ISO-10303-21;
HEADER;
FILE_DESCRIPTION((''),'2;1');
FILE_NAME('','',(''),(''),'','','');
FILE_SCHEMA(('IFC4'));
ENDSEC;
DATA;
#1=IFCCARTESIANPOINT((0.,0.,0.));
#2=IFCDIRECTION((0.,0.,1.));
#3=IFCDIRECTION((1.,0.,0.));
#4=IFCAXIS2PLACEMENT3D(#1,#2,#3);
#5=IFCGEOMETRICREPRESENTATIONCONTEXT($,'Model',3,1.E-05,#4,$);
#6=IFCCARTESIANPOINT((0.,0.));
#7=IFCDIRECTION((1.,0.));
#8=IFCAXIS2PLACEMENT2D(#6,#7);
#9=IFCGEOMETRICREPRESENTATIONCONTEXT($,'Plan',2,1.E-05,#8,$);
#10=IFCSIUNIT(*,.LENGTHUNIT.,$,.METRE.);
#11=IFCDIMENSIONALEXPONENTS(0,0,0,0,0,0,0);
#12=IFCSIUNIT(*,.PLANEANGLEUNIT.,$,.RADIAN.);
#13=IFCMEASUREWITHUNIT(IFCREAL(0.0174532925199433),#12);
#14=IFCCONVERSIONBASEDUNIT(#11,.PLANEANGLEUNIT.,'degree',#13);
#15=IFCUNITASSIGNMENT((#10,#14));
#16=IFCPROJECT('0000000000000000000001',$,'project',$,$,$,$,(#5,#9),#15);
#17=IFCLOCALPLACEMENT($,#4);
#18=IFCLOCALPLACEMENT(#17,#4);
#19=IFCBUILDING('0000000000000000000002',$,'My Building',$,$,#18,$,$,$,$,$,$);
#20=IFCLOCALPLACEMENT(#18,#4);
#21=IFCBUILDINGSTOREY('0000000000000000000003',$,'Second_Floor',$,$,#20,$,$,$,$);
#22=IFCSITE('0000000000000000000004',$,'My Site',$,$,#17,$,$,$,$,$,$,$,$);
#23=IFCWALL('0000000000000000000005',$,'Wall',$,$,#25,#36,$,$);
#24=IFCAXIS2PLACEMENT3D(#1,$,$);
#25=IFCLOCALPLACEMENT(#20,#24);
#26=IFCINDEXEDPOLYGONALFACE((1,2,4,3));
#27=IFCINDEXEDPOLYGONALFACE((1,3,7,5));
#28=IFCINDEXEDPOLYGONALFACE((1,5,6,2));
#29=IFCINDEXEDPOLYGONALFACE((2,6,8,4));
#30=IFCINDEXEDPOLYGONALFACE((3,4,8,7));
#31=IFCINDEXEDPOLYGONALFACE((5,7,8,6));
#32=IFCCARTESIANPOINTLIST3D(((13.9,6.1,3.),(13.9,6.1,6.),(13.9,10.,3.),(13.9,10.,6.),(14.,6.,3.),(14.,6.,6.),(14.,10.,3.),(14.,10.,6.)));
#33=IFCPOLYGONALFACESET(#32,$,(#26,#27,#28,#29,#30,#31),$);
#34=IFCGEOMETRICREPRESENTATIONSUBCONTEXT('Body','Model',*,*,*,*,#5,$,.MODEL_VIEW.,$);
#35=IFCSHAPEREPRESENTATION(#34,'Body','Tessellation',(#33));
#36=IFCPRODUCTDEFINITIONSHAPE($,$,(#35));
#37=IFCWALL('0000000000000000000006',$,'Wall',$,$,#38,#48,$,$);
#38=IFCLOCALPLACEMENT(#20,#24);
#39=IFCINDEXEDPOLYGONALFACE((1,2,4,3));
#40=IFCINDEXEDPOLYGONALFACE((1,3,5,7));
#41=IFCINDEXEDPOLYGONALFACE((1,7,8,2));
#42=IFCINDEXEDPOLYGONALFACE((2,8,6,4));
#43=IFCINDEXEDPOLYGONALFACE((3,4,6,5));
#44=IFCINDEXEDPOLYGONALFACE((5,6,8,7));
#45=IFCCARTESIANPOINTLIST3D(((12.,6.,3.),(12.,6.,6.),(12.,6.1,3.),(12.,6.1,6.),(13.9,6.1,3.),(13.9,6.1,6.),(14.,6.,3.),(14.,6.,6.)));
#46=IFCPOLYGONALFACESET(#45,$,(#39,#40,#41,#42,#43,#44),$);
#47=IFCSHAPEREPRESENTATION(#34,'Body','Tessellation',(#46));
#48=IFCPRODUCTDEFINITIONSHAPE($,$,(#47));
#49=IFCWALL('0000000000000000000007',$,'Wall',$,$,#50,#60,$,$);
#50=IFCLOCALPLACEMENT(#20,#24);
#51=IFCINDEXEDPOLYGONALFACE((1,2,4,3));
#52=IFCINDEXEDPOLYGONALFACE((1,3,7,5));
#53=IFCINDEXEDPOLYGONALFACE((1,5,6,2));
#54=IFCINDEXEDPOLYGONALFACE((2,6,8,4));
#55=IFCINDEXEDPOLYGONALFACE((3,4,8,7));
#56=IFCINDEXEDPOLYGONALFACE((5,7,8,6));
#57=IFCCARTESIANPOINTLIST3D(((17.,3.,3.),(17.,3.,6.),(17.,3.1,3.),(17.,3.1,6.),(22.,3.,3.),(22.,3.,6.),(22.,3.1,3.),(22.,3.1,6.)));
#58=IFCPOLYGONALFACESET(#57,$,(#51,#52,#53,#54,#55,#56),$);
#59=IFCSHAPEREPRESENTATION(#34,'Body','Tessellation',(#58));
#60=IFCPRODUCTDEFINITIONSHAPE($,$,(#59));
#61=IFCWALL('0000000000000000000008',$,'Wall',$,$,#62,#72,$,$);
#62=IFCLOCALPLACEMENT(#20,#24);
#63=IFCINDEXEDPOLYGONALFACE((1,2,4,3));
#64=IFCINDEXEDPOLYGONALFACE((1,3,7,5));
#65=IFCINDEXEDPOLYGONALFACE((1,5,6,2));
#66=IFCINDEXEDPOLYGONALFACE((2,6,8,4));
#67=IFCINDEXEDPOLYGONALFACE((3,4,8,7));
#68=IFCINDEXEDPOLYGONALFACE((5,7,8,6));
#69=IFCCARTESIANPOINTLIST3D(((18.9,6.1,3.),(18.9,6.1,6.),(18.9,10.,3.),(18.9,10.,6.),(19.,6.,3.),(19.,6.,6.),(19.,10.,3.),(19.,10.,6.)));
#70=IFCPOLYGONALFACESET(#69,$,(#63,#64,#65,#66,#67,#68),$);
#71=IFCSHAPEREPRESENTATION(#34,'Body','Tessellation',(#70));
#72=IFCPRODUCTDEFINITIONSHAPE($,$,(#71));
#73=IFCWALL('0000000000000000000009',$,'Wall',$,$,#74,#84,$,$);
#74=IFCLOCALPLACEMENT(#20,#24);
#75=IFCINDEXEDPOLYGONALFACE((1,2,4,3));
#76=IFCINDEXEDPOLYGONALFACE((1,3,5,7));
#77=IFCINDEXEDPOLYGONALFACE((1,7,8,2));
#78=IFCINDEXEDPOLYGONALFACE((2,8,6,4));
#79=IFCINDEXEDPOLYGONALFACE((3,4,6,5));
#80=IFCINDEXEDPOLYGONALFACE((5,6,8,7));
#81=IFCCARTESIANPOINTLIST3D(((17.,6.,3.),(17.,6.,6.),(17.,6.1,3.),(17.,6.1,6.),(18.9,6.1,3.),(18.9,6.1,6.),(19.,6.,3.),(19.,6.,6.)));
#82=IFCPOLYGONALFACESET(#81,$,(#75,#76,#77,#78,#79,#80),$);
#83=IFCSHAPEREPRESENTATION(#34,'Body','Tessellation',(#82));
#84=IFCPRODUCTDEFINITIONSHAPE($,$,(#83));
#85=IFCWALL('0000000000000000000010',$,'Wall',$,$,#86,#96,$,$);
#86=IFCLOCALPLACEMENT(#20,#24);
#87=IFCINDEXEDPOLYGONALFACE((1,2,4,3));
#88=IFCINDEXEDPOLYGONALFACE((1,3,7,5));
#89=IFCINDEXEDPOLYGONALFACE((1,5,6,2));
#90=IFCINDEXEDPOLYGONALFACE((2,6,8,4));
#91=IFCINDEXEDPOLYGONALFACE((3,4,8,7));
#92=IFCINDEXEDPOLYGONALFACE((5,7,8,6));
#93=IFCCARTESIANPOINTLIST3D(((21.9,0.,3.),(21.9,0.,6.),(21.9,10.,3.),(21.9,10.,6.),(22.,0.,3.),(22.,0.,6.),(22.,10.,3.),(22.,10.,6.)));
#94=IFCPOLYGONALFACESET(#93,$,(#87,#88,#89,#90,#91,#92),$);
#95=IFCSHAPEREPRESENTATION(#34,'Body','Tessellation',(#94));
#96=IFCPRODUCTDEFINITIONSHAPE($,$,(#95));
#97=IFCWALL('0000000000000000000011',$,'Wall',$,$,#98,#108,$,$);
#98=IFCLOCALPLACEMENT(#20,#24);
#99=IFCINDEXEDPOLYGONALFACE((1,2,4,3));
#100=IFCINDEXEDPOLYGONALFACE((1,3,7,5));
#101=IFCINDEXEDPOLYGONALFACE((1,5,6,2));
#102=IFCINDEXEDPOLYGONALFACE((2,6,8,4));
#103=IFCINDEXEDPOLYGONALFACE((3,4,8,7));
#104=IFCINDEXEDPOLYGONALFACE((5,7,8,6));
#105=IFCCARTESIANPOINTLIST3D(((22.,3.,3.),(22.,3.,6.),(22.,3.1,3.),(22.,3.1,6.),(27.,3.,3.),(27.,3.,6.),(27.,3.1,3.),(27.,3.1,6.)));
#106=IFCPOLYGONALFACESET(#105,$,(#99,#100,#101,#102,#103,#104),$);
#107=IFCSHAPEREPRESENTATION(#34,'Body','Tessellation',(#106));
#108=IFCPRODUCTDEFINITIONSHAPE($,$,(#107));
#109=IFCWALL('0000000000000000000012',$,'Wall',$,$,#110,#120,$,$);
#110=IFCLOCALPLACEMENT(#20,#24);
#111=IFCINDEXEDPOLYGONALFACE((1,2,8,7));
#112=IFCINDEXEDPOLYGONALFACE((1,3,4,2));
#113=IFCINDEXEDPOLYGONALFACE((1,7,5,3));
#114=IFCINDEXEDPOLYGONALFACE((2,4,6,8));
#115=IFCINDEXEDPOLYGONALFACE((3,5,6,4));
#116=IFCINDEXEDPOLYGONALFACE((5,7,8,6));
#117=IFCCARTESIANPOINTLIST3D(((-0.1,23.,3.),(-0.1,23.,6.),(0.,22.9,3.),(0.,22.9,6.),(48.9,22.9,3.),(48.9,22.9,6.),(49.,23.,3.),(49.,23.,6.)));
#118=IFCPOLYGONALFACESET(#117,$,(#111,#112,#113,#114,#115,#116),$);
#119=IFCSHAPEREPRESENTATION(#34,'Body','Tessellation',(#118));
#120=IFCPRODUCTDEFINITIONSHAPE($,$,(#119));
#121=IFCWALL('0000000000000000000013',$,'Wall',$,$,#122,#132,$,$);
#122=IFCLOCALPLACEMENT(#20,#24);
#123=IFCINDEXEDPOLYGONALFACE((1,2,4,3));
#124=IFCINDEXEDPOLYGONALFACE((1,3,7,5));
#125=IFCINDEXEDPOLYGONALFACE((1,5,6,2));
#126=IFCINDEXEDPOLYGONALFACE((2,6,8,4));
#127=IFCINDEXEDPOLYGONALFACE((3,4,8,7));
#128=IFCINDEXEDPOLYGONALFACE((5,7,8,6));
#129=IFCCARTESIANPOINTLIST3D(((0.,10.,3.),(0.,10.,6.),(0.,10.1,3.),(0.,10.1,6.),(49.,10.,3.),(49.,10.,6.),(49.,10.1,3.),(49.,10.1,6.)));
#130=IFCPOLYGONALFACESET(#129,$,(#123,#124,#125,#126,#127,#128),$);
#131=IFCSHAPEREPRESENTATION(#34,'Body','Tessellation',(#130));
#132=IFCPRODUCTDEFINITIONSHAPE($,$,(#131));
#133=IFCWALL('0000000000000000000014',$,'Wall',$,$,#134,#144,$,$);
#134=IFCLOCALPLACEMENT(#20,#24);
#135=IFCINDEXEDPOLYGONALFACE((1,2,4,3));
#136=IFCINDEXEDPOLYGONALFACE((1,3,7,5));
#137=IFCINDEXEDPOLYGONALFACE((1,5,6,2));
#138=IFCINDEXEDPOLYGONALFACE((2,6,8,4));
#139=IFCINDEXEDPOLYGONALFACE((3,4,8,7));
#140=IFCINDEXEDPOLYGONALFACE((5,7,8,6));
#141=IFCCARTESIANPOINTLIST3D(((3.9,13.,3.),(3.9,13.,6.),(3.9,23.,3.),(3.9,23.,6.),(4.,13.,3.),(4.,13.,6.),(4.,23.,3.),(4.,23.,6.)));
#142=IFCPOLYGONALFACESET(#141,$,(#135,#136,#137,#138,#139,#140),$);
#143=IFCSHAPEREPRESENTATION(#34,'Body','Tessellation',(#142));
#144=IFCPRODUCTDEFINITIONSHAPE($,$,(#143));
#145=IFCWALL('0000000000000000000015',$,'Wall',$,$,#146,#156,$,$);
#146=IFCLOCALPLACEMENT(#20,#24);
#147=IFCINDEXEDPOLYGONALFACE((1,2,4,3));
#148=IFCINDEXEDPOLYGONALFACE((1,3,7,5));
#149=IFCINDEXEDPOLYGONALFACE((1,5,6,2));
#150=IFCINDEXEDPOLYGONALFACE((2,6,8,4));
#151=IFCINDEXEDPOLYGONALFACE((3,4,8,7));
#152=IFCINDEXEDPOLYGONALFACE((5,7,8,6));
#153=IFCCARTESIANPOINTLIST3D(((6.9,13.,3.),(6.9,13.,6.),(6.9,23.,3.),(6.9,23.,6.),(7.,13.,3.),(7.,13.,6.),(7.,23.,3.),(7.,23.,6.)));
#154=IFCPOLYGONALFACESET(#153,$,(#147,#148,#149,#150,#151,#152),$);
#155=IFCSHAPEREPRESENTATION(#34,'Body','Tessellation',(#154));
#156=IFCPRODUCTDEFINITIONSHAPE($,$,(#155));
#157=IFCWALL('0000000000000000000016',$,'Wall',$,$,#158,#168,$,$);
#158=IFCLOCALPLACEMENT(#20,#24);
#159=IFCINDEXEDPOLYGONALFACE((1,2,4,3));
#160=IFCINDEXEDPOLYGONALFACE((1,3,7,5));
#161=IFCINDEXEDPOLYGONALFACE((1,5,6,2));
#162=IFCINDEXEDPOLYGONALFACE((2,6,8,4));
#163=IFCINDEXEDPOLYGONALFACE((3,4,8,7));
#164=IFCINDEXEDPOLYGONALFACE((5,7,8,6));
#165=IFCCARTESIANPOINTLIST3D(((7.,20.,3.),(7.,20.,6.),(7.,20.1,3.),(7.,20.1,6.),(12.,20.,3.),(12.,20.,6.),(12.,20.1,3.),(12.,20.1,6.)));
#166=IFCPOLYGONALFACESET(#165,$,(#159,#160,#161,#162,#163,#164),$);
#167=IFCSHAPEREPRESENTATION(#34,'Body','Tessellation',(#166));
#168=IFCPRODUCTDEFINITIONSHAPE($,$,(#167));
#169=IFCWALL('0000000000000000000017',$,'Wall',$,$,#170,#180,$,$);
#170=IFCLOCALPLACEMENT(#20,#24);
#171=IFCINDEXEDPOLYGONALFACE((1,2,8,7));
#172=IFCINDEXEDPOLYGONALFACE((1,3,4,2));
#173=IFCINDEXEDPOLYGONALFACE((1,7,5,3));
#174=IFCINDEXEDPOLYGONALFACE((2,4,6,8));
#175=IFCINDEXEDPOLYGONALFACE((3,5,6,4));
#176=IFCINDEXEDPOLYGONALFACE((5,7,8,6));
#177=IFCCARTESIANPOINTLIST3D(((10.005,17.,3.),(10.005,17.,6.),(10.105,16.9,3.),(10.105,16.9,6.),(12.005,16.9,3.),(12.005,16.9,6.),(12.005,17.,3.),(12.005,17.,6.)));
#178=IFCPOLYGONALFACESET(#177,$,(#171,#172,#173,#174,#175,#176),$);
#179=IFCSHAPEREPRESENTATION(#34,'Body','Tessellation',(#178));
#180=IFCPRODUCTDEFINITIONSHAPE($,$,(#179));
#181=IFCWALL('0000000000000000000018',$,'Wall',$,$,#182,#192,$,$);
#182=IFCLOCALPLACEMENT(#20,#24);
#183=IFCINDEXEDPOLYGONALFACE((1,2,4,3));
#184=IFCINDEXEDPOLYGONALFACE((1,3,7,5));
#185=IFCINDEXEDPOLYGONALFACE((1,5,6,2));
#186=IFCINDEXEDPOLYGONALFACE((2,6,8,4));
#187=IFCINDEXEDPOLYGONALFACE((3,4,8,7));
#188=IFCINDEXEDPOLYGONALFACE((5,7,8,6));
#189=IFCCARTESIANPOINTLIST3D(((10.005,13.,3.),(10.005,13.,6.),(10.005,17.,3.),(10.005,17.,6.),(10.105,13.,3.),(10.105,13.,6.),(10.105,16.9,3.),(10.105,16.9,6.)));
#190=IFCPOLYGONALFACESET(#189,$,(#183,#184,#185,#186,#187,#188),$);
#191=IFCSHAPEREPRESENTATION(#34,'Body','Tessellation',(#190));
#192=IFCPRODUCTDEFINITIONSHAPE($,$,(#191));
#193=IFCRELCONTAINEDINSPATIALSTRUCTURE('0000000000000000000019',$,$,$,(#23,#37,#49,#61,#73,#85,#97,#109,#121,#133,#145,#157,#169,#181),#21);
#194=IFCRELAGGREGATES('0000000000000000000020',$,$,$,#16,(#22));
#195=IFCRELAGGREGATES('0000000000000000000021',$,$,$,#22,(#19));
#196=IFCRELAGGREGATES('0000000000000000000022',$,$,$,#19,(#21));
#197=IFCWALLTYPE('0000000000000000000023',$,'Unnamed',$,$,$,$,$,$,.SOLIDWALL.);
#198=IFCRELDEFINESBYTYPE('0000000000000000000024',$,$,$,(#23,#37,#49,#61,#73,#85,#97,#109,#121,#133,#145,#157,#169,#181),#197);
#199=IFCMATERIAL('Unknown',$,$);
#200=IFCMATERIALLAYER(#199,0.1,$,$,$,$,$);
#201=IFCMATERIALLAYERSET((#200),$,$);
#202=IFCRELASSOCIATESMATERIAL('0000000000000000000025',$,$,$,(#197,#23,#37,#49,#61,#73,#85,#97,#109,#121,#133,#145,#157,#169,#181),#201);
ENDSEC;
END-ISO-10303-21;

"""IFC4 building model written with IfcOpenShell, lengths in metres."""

from ifc_helpers import new_model, entity, si_unit, converted_unit, frame, origin_with_axes, origin_2d_with_axis, place, context, subcontext, project, spatial, line, indexed_curve, outline, extrude, material, layer, layer_set, layer_usage, type_object, element, save


model = new_model("IFC4")

# Units and contexts
model_context = context("Model", 3, precision=1e-05, world=origin_with_axes())
plan_context = context("Plan", 2, precision=1e-05, world=origin_2d_with_axis())
body_context = subcontext(model_context, "Body", "Model", "MODEL_VIEW")
ifc_project = project(units=[si_unit("LENGTHUNIT", "METRE"), converted_unit("PLANEANGLEUNIT", "degree", entity("IfcReal", 0.0174532925199433), si_unit("PLANEANGLEUNIT", "RADIAN"), dimensions=[0, 0, 0, 0, 0, 0, 0])], contexts=[model_context, plan_context])

# Site, building, storey
site_placement = place(None, origin_with_axes())
site = spatial("IfcSite", under=ifc_project, at=site_placement, Name="My Site")
building_placement = place(site_placement, origin_with_axes())
building = spatial("IfcBuilding", under=site, at=building_placement, Name="My Building")
storey_placement = place(building_placement, origin_with_axes())
storey = spatial("IfcBuildingStorey", under=building, at=storey_placement, Name="Second_Floor")

# Shared definitions
ifc_material = material(Name="Unknown")

# Walls
ifc_layer_1 = layer(ifc_material, 0.1)
ifc_layer_set_1 = layer_set([ifc_layer_1])
wall_type = type_object("IfcWallType", Name="Unnamed", PredefinedType="SOLIDWALL", material=ifc_layer_set_1)
ifc_layer_usage_1 = layer_usage(ifc_layer_set_1, "AXIS2", "POSITIVE", 0.0)
wall_1_placement = place(storey_placement, frame((14.0, 6.0, 3.0), z_axis=(0.0, 0.0, 1.0), x_axis=(0.0, 1.0, 0.0)))
element("IfcWall", 1, at=wall_1_placement, inside=storey, type_object=wall_type, material=ifc_layer_usage_1, Name="Wall", context=body_context, shape_type="SweptSolid", body=[
    extrude(outline(indexed_curve([(0.0, 0.0), (0.1, 0.1), (4.0, 0.1), (4.0, 0.0)], segments=[line(1, 2, 3, 4, 1)])), origin_with_axes(), (0.0, 0.0, 1.0), 3.0),
])
ifc_layer_usage_2 = layer_usage(ifc_layer_set_1, "AXIS2", "POSITIVE", 0.0)
wall_2_placement = place(storey_placement, frame((12.0, 6.0, 3.0), z_axis=(0.0, 0.0, 1.0), x_axis=(1.0, 0.0, 0.0)))
element("IfcWall", 2, at=wall_2_placement, inside=storey, type_object=wall_type, material=ifc_layer_usage_2, Name="Wall", context=body_context, shape_type="SweptSolid", body=[
    extrude(outline(indexed_curve([(0.0, 0.0), (0.0, 0.1), (1.9, 0.1), (2.0, 0.0)], segments=[line(1, 2, 3, 4, 1)])), origin_with_axes(), (0.0, 0.0, 1.0), 3.0),
])
ifc_layer_usage_3 = layer_usage(ifc_layer_set_1, "AXIS2", "POSITIVE", 0.0)
wall_3_placement = place(storey_placement, frame((17.0, 3.0, 3.0), z_axis=(0.0, 0.0, 1.0), x_axis=(1.0, 0.0, 0.0)))
element("IfcWall", 3, at=wall_3_placement, inside=storey, type_object=wall_type, material=ifc_layer_usage_3, Name="Wall", context=body_context, shape_type="SweptSolid", body=[
    extrude(outline(indexed_curve([(0.0, 0.0), (0.0, 0.1), (5.0, 0.1), (5.0, 0.0)], segments=[line(1, 2, 3, 4, 1)])), origin_with_axes(), (0.0, 0.0, 1.0), 3.0),
])
ifc_layer_usage_4 = layer_usage(ifc_layer_set_1, "AXIS2", "POSITIVE", 0.0)
wall_4_placement = place(storey_placement, frame((19.0, 6.0, 3.0), z_axis=(0.0, 0.0, 1.0), x_axis=(0.0, 1.0, 0.0)))
element("IfcWall", 4, at=wall_4_placement, inside=storey, type_object=wall_type, material=ifc_layer_usage_4, Name="Wall", context=body_context, shape_type="SweptSolid", body=[
    extrude(outline(indexed_curve([(0.0, 0.0), (0.1, 0.1), (4.0, 0.1), (4.0, 0.0)], segments=[line(1, 2, 3, 4, 1)])), origin_with_axes(), (0.0, 0.0, 1.0), 3.0),
])
ifc_layer_usage_5 = layer_usage(ifc_layer_set_1, "AXIS2", "POSITIVE", 0.0)
wall_5_placement = place(storey_placement, frame((17.0, 6.0, 3.0), z_axis=(0.0, 0.0, 1.0), x_axis=(1.0, 0.0, 0.0)))
element("IfcWall", 5, at=wall_5_placement, inside=storey, type_object=wall_type, material=ifc_layer_usage_5, Name="Wall", context=body_context, shape_type="SweptSolid", body=[
    extrude(outline(indexed_curve([(0.0, 0.0), (0.0, 0.1), (1.9, 0.1), (2.0, 0.0)], segments=[line(1, 2, 3, 4, 1)])), origin_with_axes(), (0.0, 0.0, 1.0), 3.0),
])
ifc_layer_usage_6 = layer_usage(ifc_layer_set_1, "AXIS2", "POSITIVE", 0.0)
wall_6_placement = place(storey_placement, frame((21.9, 10.0, 3.0), z_axis=(0.0, 0.0, 1.0), x_axis=(0.0, -1.0, 0.0)))
element("IfcWall", 6, at=wall_6_placement, inside=storey, type_object=wall_type, material=ifc_layer_usage_6, Name="Wall", context=body_context, shape_type="SweptSolid", body=[
    extrude(outline(indexed_curve([(0.0, 0.0), (0.0, 0.1), (10.0, 0.1), (10.0, 0.0)], segments=[line(1, 2, 3, 4, 1)])), origin_with_axes(), (0.0, 0.0, 1.0), 3.0),
])
ifc_layer_usage_7 = layer_usage(ifc_layer_set_1, "AXIS2", "POSITIVE", 0.0)
wall_7_placement = place(storey_placement, frame((22.0, 3.0, 3.0), z_axis=(0.0, 0.0, 1.0), x_axis=(1.0, 0.0, 0.0)))
element("IfcWall", 7, at=wall_7_placement, inside=storey, type_object=wall_type, material=ifc_layer_usage_7, Name="Wall", context=body_context, shape_type="SweptSolid", body=[
    extrude(outline(indexed_curve([(0.0, 0.0), (0.0, 0.1), (5.0, 0.1), (5.0, 0.0)], segments=[line(1, 2, 3, 4, 1)])), origin_with_axes(), (0.0, 0.0, 1.0), 3.0),
])
ifc_layer_usage_8 = layer_usage(ifc_layer_set_1, "AXIS2", "POSITIVE", 0.0)
wall_8_placement = place(storey_placement, frame((0.0, 22.9, 3.0), z_axis=(0.0, 0.0, 1.0), x_axis=(1.0, 0.0, 0.0)))
element("IfcWall", 8, at=wall_8_placement, inside=storey, type_object=wall_type, material=ifc_layer_usage_8, Name="Wall", context=body_context, shape_type="SweptSolid", body=[
    extrude(outline(indexed_curve([(0.0, 0.0), (-0.1, 0.1), (49.0, 0.1), (48.9, 0.0)], segments=[line(1, 2, 3, 4, 1)])), origin_with_axes(), (0.0, 0.0, 1.0), 3.0),
])
ifc_layer_usage_9 = layer_usage(ifc_layer_set_1, "AXIS2", "POSITIVE", 0.0)
wall_9_placement = place(storey_placement, frame((0.0, 10.0, 3.0), z_axis=(0.0, 0.0, 1.0), x_axis=(1.0, 0.0, 0.0)))
element("IfcWall", 9, at=wall_9_placement, inside=storey, type_object=wall_type, material=ifc_layer_usage_9, Name="Wall", context=body_context, shape_type="SweptSolid", body=[
    extrude(outline(indexed_curve([(0.0, 0.0), (0.0, 0.1), (49.0, 0.1), (49.0, 0.0)], segments=[line(1, 2, 3, 4, 1)])), origin_with_axes(), (0.0, 0.0, 1.0), 3.0),
])
ifc_layer_usage_10 = layer_usage(ifc_layer_set_1, "AXIS2", "POSITIVE", 0.0)
wall_10_placement = place(storey_placement, frame((3.9, 23.0, 3.0), z_axis=(0.0, 0.0, 1.0), x_axis=(0.0, -1.0, 0.0)))
element("IfcWall", 10, at=wall_10_placement, inside=storey, type_object=wall_type, material=ifc_layer_usage_10, Name="Wall", context=body_context, shape_type="SweptSolid", body=[
    extrude(outline(indexed_curve([(0.0, 0.0), (0.0, 0.1), (10.0, 0.1), (10.0, 0.0)], segments=[line(1, 2, 3, 4, 1)])), origin_with_axes(), (0.0, 0.0, 1.0), 3.0),
])
ifc_layer_usage_11 = layer_usage(ifc_layer_set_1, "AXIS2", "POSITIVE", 0.0)
wall_11_placement = place(storey_placement, frame((6.9, 23.0, 3.0), z_axis=(0.0, 0.0, 1.0), x_axis=(0.0, -1.0, 0.0)))
element("IfcWall", 11, at=wall_11_placement, inside=storey, type_object=wall_type, material=ifc_layer_usage_11, Name="Wall", context=body_context, shape_type="SweptSolid", body=[
    extrude(outline(indexed_curve([(0.0, 0.0), (0.0, 0.1), (10.0, 0.1), (10.0, 0.0)], segments=[line(1, 2, 3, 4, 1)])), origin_with_axes(), (0.0, 0.0, 1.0), 3.0),
])
ifc_layer_usage_12 = layer_usage(ifc_layer_set_1, "AXIS2", "POSITIVE", 0.0)
wall_12_placement = place(storey_placement, frame((7.0, 20.0, 3.0), z_axis=(0.0, 0.0, 1.0), x_axis=(1.0, 0.0, 0.0)))
element("IfcWall", 12, at=wall_12_placement, inside=storey, type_object=wall_type, material=ifc_layer_usage_12, Name="Wall", context=body_context, shape_type="SweptSolid", body=[
    extrude(outline(indexed_curve([(0.0, 0.0), (0.0, 0.1), (5.0, 0.1), (5.0, 0.0)], segments=[line(1, 2, 3, 4, 1)])), origin_with_axes(), (0.0, 0.0, 1.0), 3.0),
])
ifc_layer_usage_13 = layer_usage(ifc_layer_set_1, "AXIS2", "POSITIVE", 0.0)
wall_13_placement = place(storey_placement, frame((12.005, 17.0, 3.0), z_axis=(0.0, 0.0, 1.0), x_axis=(-1.0, 0.0, 0.0)))
element("IfcWall", 13, at=wall_13_placement, inside=storey, type_object=wall_type, material=ifc_layer_usage_13, Name="Wall", context=body_context, shape_type="SweptSolid", body=[
    extrude(outline(indexed_curve([(0.0, 0.0), (0.0, 0.1), (1.9, 0.1), (2.0, 0.0)], segments=[line(1, 2, 3, 4, 1)])), origin_with_axes(), (0.0, 0.0, 1.0), 3.0),
])
ifc_layer_usage_14 = layer_usage(ifc_layer_set_1, "AXIS2", "POSITIVE", 0.0)
wall_14_placement = place(storey_placement, frame((10.005, 17.0, 3.0), z_axis=(0.0, 0.0, 1.0), x_axis=(0.0, -1.0, 0.0)))
element("IfcWall", 14, at=wall_14_placement, inside=storey, type_object=wall_type, material=ifc_layer_usage_14, Name="Wall", context=body_context, shape_type="SweptSolid", body=[
    extrude(outline(indexed_curve([(0.0, 0.0), (0.1, 0.1), (4.0, 0.1), (4.0, 0.0)], segments=[line(1, 2, 3, 4, 1)])), origin_with_axes(), (0.0, 0.0, 1.0), 3.0),
])

save(model, "model.ifc")
